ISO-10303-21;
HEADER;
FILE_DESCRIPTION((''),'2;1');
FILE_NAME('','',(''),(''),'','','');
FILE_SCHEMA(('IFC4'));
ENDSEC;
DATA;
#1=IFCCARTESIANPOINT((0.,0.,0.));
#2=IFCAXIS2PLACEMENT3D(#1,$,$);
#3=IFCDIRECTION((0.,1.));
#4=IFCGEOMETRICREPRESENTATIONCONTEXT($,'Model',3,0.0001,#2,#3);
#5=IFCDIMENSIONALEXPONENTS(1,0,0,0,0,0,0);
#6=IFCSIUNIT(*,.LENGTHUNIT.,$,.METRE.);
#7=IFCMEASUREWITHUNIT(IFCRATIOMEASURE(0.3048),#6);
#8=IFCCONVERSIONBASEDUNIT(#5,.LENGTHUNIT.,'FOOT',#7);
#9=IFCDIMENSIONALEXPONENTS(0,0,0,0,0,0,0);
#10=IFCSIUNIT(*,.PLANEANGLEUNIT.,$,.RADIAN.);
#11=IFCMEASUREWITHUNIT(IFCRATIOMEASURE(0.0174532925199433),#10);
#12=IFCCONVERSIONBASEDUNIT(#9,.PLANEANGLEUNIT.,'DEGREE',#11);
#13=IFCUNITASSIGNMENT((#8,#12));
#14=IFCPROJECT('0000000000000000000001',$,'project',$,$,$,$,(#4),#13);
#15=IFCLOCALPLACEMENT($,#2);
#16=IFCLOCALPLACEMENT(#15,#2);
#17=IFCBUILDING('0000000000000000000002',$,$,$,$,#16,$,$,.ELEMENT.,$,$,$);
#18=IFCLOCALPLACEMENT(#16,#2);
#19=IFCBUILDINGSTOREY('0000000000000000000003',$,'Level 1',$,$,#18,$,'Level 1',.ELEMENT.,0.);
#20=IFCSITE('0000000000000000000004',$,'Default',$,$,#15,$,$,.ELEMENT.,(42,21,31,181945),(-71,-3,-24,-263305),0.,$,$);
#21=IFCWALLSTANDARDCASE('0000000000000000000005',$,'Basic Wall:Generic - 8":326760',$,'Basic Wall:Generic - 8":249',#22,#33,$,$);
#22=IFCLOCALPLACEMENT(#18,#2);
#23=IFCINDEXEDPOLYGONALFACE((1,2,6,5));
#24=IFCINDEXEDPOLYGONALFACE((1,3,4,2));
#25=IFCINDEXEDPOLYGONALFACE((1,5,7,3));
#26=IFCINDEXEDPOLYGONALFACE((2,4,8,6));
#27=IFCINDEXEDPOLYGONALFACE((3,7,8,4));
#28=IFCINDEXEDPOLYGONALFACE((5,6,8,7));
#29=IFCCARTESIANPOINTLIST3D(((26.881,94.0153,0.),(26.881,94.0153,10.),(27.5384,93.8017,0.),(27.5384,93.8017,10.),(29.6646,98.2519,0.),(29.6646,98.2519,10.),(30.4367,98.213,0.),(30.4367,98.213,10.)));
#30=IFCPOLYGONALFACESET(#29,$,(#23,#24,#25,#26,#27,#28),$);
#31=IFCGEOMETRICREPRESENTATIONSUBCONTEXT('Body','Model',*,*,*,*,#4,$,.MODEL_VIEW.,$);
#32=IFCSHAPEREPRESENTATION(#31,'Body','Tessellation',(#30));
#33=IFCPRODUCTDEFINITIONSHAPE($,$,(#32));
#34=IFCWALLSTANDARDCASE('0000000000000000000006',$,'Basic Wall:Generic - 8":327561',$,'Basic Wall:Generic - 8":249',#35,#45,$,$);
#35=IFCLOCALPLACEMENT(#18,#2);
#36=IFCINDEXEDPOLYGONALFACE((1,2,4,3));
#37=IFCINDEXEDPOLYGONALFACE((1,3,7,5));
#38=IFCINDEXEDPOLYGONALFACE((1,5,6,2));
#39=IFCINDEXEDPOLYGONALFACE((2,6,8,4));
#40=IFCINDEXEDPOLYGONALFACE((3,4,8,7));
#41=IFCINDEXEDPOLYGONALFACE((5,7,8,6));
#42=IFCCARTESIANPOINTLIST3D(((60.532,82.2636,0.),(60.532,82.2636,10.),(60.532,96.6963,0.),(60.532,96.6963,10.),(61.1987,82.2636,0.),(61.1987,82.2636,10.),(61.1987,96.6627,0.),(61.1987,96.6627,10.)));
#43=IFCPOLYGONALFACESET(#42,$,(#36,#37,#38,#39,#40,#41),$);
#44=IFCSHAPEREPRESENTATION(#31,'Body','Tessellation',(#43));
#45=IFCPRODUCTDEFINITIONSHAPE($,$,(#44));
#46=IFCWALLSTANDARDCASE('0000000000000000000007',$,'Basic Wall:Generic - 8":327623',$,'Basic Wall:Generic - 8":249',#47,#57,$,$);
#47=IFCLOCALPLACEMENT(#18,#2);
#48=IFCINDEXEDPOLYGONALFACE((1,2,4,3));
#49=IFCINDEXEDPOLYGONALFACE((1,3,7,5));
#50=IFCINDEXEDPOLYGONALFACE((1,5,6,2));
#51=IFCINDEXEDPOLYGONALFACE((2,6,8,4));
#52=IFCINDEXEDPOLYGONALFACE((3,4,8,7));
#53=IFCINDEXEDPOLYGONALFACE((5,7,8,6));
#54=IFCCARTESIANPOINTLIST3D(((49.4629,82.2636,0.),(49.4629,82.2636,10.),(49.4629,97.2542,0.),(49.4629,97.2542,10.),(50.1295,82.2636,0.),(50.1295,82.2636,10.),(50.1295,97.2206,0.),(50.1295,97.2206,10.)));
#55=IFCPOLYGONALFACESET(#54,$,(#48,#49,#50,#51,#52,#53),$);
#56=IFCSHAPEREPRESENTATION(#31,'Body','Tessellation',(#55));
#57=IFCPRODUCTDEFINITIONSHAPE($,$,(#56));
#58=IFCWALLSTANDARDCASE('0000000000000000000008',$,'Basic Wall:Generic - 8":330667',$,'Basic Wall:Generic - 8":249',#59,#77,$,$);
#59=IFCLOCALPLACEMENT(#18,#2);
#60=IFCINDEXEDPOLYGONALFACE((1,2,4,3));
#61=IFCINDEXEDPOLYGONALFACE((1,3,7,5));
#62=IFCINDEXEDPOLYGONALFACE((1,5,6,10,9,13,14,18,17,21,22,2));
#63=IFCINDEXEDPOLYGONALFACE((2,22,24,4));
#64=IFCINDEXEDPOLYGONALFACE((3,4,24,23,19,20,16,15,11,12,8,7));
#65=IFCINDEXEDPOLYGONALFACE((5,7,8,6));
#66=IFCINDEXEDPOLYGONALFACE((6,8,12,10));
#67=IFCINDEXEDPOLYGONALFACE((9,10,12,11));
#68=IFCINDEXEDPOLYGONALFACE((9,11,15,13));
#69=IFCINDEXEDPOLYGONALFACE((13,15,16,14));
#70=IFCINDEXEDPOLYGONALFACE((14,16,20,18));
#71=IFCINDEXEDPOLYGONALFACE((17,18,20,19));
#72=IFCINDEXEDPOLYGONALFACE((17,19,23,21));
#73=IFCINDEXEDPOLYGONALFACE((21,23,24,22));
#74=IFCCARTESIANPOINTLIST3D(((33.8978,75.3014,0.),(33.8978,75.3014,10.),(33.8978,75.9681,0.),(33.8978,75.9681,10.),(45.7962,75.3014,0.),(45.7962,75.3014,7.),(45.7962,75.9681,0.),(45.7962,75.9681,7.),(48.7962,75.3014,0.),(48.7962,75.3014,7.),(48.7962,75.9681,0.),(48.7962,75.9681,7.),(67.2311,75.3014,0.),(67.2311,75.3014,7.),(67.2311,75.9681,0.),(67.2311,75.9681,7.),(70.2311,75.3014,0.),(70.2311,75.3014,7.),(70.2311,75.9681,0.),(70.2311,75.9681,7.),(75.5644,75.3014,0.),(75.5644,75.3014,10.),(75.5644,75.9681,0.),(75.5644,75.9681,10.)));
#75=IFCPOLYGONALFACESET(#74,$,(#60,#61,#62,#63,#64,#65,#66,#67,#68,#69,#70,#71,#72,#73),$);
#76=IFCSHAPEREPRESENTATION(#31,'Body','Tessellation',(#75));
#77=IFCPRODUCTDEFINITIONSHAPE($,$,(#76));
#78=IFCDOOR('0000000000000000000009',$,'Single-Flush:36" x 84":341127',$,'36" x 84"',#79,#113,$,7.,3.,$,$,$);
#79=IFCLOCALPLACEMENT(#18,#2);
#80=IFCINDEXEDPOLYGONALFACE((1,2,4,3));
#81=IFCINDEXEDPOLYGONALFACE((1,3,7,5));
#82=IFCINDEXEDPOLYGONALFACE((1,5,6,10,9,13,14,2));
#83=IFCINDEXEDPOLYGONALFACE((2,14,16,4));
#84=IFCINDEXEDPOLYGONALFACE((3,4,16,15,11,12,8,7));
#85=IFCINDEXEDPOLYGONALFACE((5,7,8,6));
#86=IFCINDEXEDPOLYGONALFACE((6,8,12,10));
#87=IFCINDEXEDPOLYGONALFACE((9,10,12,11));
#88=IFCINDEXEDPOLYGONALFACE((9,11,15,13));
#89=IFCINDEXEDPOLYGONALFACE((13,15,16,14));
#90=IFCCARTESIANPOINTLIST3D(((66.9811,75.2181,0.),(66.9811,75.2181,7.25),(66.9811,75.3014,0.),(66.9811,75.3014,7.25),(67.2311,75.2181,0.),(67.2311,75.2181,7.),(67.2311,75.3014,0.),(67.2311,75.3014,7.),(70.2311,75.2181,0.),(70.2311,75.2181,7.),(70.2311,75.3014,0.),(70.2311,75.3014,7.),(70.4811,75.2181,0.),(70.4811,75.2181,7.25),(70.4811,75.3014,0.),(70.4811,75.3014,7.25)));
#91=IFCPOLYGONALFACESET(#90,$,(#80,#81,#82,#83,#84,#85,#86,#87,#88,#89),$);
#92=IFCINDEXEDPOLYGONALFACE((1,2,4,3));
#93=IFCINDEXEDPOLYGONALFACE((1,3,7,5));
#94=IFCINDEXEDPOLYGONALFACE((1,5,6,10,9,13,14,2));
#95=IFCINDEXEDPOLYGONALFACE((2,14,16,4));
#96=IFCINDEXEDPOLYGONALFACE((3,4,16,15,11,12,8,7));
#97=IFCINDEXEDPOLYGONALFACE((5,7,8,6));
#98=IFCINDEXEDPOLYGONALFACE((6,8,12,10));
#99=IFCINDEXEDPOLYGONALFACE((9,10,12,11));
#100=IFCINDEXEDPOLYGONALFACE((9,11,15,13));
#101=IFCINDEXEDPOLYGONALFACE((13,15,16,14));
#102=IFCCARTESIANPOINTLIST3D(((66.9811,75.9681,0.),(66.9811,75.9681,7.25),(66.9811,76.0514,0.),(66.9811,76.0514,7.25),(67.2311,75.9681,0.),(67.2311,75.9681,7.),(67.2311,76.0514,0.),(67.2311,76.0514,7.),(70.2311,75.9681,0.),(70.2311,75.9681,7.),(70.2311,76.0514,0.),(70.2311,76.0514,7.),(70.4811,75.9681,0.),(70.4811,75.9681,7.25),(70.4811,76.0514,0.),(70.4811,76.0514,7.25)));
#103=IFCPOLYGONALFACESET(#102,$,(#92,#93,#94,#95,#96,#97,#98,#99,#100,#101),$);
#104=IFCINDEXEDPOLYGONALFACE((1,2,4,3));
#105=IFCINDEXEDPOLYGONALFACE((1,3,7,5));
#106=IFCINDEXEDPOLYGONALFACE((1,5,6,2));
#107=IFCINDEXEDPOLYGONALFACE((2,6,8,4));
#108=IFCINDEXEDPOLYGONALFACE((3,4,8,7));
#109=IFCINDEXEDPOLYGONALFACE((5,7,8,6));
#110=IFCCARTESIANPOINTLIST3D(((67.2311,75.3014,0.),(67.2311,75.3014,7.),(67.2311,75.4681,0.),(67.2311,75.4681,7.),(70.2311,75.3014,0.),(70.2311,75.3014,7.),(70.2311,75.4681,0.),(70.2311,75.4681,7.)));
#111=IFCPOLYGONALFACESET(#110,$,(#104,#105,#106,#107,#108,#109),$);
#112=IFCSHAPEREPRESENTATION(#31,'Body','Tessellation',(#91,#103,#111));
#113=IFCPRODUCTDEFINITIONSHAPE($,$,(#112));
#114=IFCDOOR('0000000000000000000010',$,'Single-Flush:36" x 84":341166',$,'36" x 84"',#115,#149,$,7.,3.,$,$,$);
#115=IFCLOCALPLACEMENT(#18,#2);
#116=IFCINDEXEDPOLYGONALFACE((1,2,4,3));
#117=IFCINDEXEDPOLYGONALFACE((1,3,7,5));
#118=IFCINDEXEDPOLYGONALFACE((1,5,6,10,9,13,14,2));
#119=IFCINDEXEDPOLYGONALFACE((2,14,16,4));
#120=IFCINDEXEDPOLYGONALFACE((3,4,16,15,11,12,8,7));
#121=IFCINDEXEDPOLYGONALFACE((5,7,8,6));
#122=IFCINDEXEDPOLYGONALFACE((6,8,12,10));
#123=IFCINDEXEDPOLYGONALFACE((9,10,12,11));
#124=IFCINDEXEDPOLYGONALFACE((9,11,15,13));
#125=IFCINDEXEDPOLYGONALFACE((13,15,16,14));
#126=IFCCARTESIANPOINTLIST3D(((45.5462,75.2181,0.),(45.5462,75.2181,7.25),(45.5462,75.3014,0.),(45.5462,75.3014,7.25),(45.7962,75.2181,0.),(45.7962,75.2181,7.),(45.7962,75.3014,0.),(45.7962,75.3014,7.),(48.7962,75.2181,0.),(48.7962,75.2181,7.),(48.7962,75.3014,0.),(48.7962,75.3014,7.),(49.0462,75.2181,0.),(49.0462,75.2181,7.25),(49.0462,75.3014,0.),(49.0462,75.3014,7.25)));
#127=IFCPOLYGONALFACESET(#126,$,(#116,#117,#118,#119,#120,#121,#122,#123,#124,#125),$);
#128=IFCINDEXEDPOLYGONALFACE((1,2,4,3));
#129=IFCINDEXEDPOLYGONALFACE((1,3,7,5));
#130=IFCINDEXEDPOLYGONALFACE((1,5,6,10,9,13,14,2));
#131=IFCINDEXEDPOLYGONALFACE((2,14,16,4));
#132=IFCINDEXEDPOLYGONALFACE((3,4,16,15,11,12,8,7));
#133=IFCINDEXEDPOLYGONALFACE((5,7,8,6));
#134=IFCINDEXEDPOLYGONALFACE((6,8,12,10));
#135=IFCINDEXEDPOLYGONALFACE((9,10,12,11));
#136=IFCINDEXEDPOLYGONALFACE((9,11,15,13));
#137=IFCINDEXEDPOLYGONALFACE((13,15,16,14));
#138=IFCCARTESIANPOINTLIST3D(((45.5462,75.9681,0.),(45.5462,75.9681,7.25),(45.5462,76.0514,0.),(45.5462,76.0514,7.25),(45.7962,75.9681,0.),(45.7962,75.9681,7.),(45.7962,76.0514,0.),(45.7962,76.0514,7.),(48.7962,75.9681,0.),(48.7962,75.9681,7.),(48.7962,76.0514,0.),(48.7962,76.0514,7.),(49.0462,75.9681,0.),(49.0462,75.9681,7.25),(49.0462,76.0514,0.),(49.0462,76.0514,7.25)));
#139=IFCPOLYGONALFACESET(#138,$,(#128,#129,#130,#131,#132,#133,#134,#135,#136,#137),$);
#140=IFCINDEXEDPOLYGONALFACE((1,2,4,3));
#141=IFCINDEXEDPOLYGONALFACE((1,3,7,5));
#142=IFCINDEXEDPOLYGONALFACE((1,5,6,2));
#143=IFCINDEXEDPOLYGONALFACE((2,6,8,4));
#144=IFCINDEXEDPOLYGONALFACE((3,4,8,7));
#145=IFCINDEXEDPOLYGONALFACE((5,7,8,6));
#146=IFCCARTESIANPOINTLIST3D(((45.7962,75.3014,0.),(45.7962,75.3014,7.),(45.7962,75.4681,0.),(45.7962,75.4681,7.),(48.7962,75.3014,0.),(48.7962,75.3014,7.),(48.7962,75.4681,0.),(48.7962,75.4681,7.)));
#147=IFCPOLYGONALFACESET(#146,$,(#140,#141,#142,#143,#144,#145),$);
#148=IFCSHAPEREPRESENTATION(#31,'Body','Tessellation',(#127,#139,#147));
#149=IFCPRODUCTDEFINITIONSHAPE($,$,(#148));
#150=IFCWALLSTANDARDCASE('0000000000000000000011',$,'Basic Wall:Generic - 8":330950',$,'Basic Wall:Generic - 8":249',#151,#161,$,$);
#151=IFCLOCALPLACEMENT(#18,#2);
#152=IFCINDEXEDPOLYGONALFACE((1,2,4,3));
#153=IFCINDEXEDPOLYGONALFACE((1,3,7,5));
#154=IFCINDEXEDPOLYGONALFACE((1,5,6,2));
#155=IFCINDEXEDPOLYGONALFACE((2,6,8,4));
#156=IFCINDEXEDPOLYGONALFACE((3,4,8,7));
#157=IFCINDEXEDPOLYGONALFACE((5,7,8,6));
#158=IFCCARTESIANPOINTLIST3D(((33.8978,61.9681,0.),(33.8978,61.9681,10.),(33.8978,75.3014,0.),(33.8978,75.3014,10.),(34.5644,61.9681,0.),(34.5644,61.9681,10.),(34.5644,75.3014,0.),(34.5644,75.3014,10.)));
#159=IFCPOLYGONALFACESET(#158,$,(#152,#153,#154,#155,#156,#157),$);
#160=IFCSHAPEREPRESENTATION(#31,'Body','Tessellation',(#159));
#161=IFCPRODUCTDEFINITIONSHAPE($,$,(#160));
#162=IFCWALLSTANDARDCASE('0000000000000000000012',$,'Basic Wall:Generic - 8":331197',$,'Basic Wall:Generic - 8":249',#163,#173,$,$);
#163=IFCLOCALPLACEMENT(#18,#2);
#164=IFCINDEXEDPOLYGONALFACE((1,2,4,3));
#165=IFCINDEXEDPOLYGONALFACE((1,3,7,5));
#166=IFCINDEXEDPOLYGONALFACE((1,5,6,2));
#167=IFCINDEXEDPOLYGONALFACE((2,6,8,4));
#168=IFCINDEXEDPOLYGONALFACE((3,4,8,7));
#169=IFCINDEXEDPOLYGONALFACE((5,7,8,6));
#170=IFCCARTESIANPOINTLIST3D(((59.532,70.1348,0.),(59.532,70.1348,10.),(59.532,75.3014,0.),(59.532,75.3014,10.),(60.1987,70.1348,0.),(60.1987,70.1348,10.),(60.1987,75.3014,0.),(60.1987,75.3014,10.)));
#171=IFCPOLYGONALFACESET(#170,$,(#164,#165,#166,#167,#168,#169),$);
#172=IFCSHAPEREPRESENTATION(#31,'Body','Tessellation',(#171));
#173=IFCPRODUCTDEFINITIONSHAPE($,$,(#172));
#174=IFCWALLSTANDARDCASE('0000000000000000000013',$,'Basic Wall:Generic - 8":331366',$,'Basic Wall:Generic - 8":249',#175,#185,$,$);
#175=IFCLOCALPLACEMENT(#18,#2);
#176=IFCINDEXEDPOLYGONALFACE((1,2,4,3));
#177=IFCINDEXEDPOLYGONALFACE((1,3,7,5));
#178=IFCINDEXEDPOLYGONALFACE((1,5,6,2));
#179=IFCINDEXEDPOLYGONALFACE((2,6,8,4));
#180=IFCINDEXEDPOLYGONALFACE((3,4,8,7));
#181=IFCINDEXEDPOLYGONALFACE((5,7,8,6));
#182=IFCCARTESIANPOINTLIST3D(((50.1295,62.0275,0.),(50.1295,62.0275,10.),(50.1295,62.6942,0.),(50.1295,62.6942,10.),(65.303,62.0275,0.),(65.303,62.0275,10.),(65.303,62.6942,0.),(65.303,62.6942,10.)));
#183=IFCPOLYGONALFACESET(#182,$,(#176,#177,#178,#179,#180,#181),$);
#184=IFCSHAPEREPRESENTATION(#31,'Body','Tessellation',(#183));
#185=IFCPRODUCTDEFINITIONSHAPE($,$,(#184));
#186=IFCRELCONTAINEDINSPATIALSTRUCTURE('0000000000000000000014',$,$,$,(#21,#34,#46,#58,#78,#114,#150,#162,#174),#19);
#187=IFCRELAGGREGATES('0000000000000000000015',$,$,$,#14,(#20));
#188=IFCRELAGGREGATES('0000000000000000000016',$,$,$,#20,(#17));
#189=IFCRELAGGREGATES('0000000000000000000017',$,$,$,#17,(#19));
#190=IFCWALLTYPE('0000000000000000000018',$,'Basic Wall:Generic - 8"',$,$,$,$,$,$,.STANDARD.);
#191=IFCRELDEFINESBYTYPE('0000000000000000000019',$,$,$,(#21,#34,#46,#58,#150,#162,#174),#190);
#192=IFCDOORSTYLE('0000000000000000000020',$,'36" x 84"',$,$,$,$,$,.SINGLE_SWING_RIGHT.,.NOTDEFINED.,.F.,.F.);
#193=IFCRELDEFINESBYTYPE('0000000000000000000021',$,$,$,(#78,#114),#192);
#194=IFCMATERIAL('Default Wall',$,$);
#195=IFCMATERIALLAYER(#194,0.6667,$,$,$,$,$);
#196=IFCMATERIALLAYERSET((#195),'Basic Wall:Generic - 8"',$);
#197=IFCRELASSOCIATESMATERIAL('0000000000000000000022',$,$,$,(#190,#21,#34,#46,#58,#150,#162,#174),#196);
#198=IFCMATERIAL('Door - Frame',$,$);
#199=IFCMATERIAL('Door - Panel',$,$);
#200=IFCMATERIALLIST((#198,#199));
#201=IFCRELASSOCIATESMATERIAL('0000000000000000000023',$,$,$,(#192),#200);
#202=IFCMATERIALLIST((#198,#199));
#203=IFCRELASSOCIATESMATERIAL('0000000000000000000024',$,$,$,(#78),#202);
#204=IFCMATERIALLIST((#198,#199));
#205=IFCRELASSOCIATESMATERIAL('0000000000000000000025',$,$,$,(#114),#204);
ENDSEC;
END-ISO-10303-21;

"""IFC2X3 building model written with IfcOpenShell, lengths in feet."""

from ifc_helpers import new_model, entity, si_unit, converted_unit, direction, frame, frame_2d, origin, place, context, subcontext, project, spatial, polyline, rectangle, outline, extrude, source, transform, mapped, material, material_list, layer, layer_set, layer_usage, type_object, type_shapes, element, fill, save


model = new_model("IFC2X3")

# Units and contexts
model_context = context("Model", 3, precision=0.0001, world=origin(), true_north=direction((0.0, 1.0)))
body_context = subcontext(model_context, "Body", "Model", "MODEL_VIEW")
ifc_project = project(units=[converted_unit("LENGTHUNIT", "FOOT", entity("IfcRatioMeasure", 0.3048), si_unit("LENGTHUNIT", "METRE"), dimensions=[1, 0, 0, 0, 0, 0, 0]), converted_unit("PLANEANGLEUNIT", "DEGREE", entity("IfcRatioMeasure", 0.0174532925199433), si_unit("PLANEANGLEUNIT", "RADIAN"), dimensions=[0, 0, 0, 0, 0, 0, 0])], contexts=[model_context])

# Site, building, storey
site_placement = place(None, origin())
site = spatial("IfcSite", under=ifc_project, at=site_placement, Name="Default", CompositionType="ELEMENT", RefLatitude=(42, 21, 31, 181945), RefLongitude=(-71, -3, -24, -263305), RefElevation=0.0)
building_placement = place(site_placement, origin())
building = spatial("IfcBuilding", under=site, at=building_placement, CompositionType="ELEMENT")
storey_placement = place(building_placement, origin())
storey = spatial("IfcBuildingStorey", under=building, at=storey_placement, Name="Level 1", LongName="Level 1", CompositionType="ELEMENT", Elevation=0.0)

# Wall
ifc_material_1 = material(Name="Default Wall")
ifc_layer = layer(ifc_material_1, 0.6667)
ifc_layer_set = layer_set([ifc_layer], Name="Basic Wall:Generic - 8\"")
ifc_layer_usage_1 = layer_usage(ifc_layer_set, "AXIS2", "NEGATIVE", 0.3333)
wall_type = type_object("IfcWallType", Name="Basic Wall:Generic - 8\"", PredefinedType="STANDARD", material=ifc_layer_set)
wall_1_placement = place(storey_placement, frame((30.1581, 98.396, 0.0), z_axis=(0.0, 0.0, 1.0), x_axis=(-0.549101, -0.835756, 0.0)))
element("IfcWallStandardCase", 1, at=wall_1_placement, inside=storey, type_object=wall_type, material=ifc_layer_usage_1, Name="Basic Wall:Generic - 8\":326760", ObjectType="Basic Wall:Generic - 8\":249", context=body_context, shape_type="SweptSolid", body=[
    extrude(outline(polyline([(5.4607, -0.3333), (5.2783, 0.3333), (0.0, 0.3333), (0.3914, -0.3333), (5.4607, -0.3333)])), origin(), (0.0, 0.0, 1.0), 10.0),
])

# Shared definitions
ifc_material_2 = material(Name="Door - Frame")
ifc_material_3 = material(Name="Door - Panel")
ifc_material_list_1 = material_list([ifc_material_2, ifc_material_3])
door_style = type_object("IfcDoorStyle", Name="36\" x 84\"", ConstructionType="NOTDEFINED", OperationType="SINGLE_SWING_RIGHT", ParameterTakesPrecedence=False, Sizeable=False, material=ifc_material_list_1)
shared_shape = source(origin(), body_context, "Body", "SweptSolid", [
    extrude(outline(polyline([(-1.75, -3.6875), (1.75, -3.6875), (1.75, 3.5625), (1.5, 3.5625), (1.5, -3.4375), (-1.5, -3.4375), (-1.5, 3.5625), (-1.75, 3.5625), (-1.75, -3.6875)])), frame((1.5, 0.6667, 3.5625), z_axis=(0.0, 1.0, 0.0), x_axis=(1.0, 0.0, 0.0)), (0.0, 0.0, 1.0), 0.0833),
    extrude(outline(polyline([(-3.6875, -1.75), (3.5625, -1.75), (3.5625, -1.5), (-3.4375, -1.5), (-3.4375, 1.5), (3.5625, 1.5), (3.5625, 1.75), (-3.6875, 1.75), (-3.6875, -1.75)])), frame((1.5, -0.0833, 3.5625), z_axis=(0.0, 1.0, 0.0), x_axis=(0.0, 0.0, -1.0)), (0.0, 0.0, 1.0), 0.0833),
    extrude(rectangle(XDim=0.1667, YDim=3.0, at=frame_2d((0.0, 0.0), x_axis=(1.0, 0.0))), frame((1.5, 0.5833, 0.0), z_axis=(0.0, 0.0, 1.0), x_axis=(0.0, 1.0, 0.0)), (0.0, 0.0, 1.0), 7.0),
])
type_shapes(door_style, [shared_shape])

# Walls
ifc_layer_usage_2 = layer_usage(ifc_layer_set, "AXIS2", "NEGATIVE", 0.3333)
wall_2_placement = place(storey_placement, frame((60.8653, 96.6963, 0.0), z_axis=(0.0, 0.0, 1.0), x_axis=(0.0, -1.0, 0.0)))
element("IfcWallStandardCase", 2, at=wall_2_placement, inside=storey, type_object=wall_type, material=ifc_layer_usage_2, Name="Basic Wall:Generic - 8\":327561", ObjectType="Basic Wall:Generic - 8\":249", context=body_context, shape_type="SweptSolid", body=[
    extrude(outline(polyline([(14.4328, -0.3333), (14.4328, 0.3333), (0.0336, 0.3333), (0.0, -0.3333), (14.4328, -0.3333)])), origin(), (0.0, 0.0, 1.0), 10.0),
])
ifc_layer_usage_3 = layer_usage(ifc_layer_set, "AXIS2", "NEGATIVE", 0.3333)
wall_3_placement = place(storey_placement, frame((49.7962, 97.2542, 0.0), z_axis=(0.0, 0.0, 1.0), x_axis=(0.0, -1.0, 0.0)))
element("IfcWallStandardCase", 3, at=wall_3_placement, inside=storey, type_object=wall_type, material=ifc_layer_usage_3, Name="Basic Wall:Generic - 8\":327623", ObjectType="Basic Wall:Generic - 8\":249", context=body_context, shape_type="SweptSolid", body=[
    extrude(outline(polyline([(14.9906, -0.3333), (14.9906, 0.3333), (0.0336, 0.3333), (0.0, -0.3333), (14.9906, -0.3333)])), origin(), (0.0, 0.0, 1.0), 10.0),
])

# Wall, openings, doors
ifc_layer_usage_4 = layer_usage(ifc_layer_set, "AXIS2", "NEGATIVE", 0.3333)
wall_4_placement = place(storey_placement, frame((33.8978, 75.6348, 0.0)))
wall_4 = element("IfcWallStandardCase", 4, at=wall_4_placement, inside=storey, type_object=wall_type, material=ifc_layer_usage_4, Name="Basic Wall:Generic - 8\":330667", ObjectType="Basic Wall:Generic - 8\":249", context=body_context, shape_type="SweptSolid", body=[
    extrude(rectangle(XDim=41.6667, YDim=0.6667, at=frame_2d((20.8333, 0.0), x_axis=(-1.0, 0.0))), origin(), (0.0, 0.0, 1.0), 10.0),
])
opening_1_placement = place(wall_4_placement, frame((36.3333, 0.3333, 0.0)))
opening_1 = element("IfcOpeningElement", 5, at=opening_1_placement, cuts=wall_4, ObjectType="Opening", context=body_context, shape_type="SweptSolid", body=[
    extrude(rectangle(XDim=3.0, YDim=7.0, at=frame_2d((3.5, 1.5), x_axis=(0.0, 1.0))), frame((0.0, 0.0, 0.0), z_axis=(0.0, -1.0, 0.0), x_axis=(0.0, 0.0, 1.0)), (0.0, 0.0, 1.0), 0.6667),
])
opening_2_placement = place(wall_4_placement, frame((14.8985, 0.3333, 0.0)))
opening_2 = element("IfcOpeningElement", 6, at=opening_2_placement, cuts=wall_4, ObjectType="Opening", context=body_context, shape_type="SweptSolid", body=[
    extrude(rectangle(XDim=3.0, YDim=7.0, at=frame_2d((3.5, 1.5), x_axis=(0.0, 1.0))), frame((0.0, 0.0, 0.0), z_axis=(0.0, -1.0, 0.0), x_axis=(0.0, 0.0, 1.0)), (0.0, 0.0, 1.0), 0.6667),
])
ifc_material_list_2 = material_list([ifc_material_2, ifc_material_3])
door_1_placement = place(opening_1_placement, frame((0.0, 0.0, 0.0), z_axis=(0.0, 0.0, 1.0), x_axis=(-1.0, 0.0, 0.0)))
door_1 = element("IfcDoor", 7, at=door_1_placement, inside=storey, type_object=door_style, material=ifc_material_list_2, Name="Single-Flush:36\" x 84\":341127", ObjectType="36\" x 84\"", OverallHeight=7.0, OverallWidth=3.0, context=body_context, shape_type="MappedRepresentation", body=[
    mapped(shared_shape, transform((0.0, 0.0, 0.0), scale=1.0)),
])
fill(opening_1, door_1)
ifc_material_list_3 = material_list([ifc_material_2, ifc_material_3])
door_2_placement = place(opening_2_placement, frame((0.0, 0.0, 0.0), z_axis=(0.0, 0.0, 1.0), x_axis=(-1.0, 0.0, 0.0)))
door_2 = element("IfcDoor", 8, at=door_2_placement, inside=storey, type_object=door_style, material=ifc_material_list_3, Name="Single-Flush:36\" x 84\":341166", ObjectType="36\" x 84\"", OverallHeight=7.0, OverallWidth=3.0, context=body_context, shape_type="MappedRepresentation", body=[
    mapped(shared_shape, transform((0.0, 0.0, 0.0), scale=1.0)),
])
fill(opening_2, door_2)

# Walls
ifc_layer_usage_5 = layer_usage(ifc_layer_set, "AXIS2", "NEGATIVE", 0.3333)
wall_5_placement = place(storey_placement, frame((34.2311, 75.3014, 0.0), z_axis=(0.0, 0.0, 1.0), x_axis=(0.0, -1.0, 0.0)))
element("IfcWallStandardCase", 9, at=wall_5_placement, inside=storey, type_object=wall_type, material=ifc_layer_usage_5, Name="Basic Wall:Generic - 8\":330950", ObjectType="Basic Wall:Generic - 8\":249", context=body_context, shape_type="SweptSolid", body=[
    extrude(rectangle(XDim=13.3333, YDim=0.6667, at=frame_2d((6.6667, 0.0), x_axis=(-1.0, 0.0))), origin(), (0.0, 0.0, 1.0), 10.0),
])
ifc_layer_usage_6 = layer_usage(ifc_layer_set, "AXIS2", "NEGATIVE", 0.3333)
wall_6_placement = place(storey_placement, frame((59.8653, 75.3014, 0.0), z_axis=(0.0, 0.0, 1.0), x_axis=(0.0, -1.0, 0.0)))
element("IfcWallStandardCase", 10, at=wall_6_placement, inside=storey, type_object=wall_type, material=ifc_layer_usage_6, Name="Basic Wall:Generic - 8\":331197", ObjectType="Basic Wall:Generic - 8\":249", context=body_context, shape_type="SweptSolid", body=[
    extrude(rectangle(XDim=5.1667, YDim=0.6667, at=frame_2d((2.5833, 0.0), x_axis=(-1.0, 0.0))), origin(), (0.0, 0.0, 1.0), 10.0),
])
ifc_layer_usage_7 = layer_usage(ifc_layer_set, "AXIS2", "NEGATIVE", 0.3333)
wall_7_placement = place(storey_placement, frame((65.303, 62.3609, 0.0), z_axis=(0.0, 0.0, 1.0), x_axis=(-1.0, 0.0, 0.0)))
element("IfcWallStandardCase", 11, at=wall_7_placement, inside=storey, type_object=wall_type, material=ifc_layer_usage_7, Name="Basic Wall:Generic - 8\":331366", ObjectType="Basic Wall:Generic - 8\":249", context=body_context, shape_type="SweptSolid", body=[
    extrude(rectangle(XDim=15.1735, YDim=0.6667, at=frame_2d((7.5867, 0.0), x_axis=(-1.0, 0.0))), origin(), (0.0, 0.0, 1.0), 10.0),
])

save(model, "model.ifc")
